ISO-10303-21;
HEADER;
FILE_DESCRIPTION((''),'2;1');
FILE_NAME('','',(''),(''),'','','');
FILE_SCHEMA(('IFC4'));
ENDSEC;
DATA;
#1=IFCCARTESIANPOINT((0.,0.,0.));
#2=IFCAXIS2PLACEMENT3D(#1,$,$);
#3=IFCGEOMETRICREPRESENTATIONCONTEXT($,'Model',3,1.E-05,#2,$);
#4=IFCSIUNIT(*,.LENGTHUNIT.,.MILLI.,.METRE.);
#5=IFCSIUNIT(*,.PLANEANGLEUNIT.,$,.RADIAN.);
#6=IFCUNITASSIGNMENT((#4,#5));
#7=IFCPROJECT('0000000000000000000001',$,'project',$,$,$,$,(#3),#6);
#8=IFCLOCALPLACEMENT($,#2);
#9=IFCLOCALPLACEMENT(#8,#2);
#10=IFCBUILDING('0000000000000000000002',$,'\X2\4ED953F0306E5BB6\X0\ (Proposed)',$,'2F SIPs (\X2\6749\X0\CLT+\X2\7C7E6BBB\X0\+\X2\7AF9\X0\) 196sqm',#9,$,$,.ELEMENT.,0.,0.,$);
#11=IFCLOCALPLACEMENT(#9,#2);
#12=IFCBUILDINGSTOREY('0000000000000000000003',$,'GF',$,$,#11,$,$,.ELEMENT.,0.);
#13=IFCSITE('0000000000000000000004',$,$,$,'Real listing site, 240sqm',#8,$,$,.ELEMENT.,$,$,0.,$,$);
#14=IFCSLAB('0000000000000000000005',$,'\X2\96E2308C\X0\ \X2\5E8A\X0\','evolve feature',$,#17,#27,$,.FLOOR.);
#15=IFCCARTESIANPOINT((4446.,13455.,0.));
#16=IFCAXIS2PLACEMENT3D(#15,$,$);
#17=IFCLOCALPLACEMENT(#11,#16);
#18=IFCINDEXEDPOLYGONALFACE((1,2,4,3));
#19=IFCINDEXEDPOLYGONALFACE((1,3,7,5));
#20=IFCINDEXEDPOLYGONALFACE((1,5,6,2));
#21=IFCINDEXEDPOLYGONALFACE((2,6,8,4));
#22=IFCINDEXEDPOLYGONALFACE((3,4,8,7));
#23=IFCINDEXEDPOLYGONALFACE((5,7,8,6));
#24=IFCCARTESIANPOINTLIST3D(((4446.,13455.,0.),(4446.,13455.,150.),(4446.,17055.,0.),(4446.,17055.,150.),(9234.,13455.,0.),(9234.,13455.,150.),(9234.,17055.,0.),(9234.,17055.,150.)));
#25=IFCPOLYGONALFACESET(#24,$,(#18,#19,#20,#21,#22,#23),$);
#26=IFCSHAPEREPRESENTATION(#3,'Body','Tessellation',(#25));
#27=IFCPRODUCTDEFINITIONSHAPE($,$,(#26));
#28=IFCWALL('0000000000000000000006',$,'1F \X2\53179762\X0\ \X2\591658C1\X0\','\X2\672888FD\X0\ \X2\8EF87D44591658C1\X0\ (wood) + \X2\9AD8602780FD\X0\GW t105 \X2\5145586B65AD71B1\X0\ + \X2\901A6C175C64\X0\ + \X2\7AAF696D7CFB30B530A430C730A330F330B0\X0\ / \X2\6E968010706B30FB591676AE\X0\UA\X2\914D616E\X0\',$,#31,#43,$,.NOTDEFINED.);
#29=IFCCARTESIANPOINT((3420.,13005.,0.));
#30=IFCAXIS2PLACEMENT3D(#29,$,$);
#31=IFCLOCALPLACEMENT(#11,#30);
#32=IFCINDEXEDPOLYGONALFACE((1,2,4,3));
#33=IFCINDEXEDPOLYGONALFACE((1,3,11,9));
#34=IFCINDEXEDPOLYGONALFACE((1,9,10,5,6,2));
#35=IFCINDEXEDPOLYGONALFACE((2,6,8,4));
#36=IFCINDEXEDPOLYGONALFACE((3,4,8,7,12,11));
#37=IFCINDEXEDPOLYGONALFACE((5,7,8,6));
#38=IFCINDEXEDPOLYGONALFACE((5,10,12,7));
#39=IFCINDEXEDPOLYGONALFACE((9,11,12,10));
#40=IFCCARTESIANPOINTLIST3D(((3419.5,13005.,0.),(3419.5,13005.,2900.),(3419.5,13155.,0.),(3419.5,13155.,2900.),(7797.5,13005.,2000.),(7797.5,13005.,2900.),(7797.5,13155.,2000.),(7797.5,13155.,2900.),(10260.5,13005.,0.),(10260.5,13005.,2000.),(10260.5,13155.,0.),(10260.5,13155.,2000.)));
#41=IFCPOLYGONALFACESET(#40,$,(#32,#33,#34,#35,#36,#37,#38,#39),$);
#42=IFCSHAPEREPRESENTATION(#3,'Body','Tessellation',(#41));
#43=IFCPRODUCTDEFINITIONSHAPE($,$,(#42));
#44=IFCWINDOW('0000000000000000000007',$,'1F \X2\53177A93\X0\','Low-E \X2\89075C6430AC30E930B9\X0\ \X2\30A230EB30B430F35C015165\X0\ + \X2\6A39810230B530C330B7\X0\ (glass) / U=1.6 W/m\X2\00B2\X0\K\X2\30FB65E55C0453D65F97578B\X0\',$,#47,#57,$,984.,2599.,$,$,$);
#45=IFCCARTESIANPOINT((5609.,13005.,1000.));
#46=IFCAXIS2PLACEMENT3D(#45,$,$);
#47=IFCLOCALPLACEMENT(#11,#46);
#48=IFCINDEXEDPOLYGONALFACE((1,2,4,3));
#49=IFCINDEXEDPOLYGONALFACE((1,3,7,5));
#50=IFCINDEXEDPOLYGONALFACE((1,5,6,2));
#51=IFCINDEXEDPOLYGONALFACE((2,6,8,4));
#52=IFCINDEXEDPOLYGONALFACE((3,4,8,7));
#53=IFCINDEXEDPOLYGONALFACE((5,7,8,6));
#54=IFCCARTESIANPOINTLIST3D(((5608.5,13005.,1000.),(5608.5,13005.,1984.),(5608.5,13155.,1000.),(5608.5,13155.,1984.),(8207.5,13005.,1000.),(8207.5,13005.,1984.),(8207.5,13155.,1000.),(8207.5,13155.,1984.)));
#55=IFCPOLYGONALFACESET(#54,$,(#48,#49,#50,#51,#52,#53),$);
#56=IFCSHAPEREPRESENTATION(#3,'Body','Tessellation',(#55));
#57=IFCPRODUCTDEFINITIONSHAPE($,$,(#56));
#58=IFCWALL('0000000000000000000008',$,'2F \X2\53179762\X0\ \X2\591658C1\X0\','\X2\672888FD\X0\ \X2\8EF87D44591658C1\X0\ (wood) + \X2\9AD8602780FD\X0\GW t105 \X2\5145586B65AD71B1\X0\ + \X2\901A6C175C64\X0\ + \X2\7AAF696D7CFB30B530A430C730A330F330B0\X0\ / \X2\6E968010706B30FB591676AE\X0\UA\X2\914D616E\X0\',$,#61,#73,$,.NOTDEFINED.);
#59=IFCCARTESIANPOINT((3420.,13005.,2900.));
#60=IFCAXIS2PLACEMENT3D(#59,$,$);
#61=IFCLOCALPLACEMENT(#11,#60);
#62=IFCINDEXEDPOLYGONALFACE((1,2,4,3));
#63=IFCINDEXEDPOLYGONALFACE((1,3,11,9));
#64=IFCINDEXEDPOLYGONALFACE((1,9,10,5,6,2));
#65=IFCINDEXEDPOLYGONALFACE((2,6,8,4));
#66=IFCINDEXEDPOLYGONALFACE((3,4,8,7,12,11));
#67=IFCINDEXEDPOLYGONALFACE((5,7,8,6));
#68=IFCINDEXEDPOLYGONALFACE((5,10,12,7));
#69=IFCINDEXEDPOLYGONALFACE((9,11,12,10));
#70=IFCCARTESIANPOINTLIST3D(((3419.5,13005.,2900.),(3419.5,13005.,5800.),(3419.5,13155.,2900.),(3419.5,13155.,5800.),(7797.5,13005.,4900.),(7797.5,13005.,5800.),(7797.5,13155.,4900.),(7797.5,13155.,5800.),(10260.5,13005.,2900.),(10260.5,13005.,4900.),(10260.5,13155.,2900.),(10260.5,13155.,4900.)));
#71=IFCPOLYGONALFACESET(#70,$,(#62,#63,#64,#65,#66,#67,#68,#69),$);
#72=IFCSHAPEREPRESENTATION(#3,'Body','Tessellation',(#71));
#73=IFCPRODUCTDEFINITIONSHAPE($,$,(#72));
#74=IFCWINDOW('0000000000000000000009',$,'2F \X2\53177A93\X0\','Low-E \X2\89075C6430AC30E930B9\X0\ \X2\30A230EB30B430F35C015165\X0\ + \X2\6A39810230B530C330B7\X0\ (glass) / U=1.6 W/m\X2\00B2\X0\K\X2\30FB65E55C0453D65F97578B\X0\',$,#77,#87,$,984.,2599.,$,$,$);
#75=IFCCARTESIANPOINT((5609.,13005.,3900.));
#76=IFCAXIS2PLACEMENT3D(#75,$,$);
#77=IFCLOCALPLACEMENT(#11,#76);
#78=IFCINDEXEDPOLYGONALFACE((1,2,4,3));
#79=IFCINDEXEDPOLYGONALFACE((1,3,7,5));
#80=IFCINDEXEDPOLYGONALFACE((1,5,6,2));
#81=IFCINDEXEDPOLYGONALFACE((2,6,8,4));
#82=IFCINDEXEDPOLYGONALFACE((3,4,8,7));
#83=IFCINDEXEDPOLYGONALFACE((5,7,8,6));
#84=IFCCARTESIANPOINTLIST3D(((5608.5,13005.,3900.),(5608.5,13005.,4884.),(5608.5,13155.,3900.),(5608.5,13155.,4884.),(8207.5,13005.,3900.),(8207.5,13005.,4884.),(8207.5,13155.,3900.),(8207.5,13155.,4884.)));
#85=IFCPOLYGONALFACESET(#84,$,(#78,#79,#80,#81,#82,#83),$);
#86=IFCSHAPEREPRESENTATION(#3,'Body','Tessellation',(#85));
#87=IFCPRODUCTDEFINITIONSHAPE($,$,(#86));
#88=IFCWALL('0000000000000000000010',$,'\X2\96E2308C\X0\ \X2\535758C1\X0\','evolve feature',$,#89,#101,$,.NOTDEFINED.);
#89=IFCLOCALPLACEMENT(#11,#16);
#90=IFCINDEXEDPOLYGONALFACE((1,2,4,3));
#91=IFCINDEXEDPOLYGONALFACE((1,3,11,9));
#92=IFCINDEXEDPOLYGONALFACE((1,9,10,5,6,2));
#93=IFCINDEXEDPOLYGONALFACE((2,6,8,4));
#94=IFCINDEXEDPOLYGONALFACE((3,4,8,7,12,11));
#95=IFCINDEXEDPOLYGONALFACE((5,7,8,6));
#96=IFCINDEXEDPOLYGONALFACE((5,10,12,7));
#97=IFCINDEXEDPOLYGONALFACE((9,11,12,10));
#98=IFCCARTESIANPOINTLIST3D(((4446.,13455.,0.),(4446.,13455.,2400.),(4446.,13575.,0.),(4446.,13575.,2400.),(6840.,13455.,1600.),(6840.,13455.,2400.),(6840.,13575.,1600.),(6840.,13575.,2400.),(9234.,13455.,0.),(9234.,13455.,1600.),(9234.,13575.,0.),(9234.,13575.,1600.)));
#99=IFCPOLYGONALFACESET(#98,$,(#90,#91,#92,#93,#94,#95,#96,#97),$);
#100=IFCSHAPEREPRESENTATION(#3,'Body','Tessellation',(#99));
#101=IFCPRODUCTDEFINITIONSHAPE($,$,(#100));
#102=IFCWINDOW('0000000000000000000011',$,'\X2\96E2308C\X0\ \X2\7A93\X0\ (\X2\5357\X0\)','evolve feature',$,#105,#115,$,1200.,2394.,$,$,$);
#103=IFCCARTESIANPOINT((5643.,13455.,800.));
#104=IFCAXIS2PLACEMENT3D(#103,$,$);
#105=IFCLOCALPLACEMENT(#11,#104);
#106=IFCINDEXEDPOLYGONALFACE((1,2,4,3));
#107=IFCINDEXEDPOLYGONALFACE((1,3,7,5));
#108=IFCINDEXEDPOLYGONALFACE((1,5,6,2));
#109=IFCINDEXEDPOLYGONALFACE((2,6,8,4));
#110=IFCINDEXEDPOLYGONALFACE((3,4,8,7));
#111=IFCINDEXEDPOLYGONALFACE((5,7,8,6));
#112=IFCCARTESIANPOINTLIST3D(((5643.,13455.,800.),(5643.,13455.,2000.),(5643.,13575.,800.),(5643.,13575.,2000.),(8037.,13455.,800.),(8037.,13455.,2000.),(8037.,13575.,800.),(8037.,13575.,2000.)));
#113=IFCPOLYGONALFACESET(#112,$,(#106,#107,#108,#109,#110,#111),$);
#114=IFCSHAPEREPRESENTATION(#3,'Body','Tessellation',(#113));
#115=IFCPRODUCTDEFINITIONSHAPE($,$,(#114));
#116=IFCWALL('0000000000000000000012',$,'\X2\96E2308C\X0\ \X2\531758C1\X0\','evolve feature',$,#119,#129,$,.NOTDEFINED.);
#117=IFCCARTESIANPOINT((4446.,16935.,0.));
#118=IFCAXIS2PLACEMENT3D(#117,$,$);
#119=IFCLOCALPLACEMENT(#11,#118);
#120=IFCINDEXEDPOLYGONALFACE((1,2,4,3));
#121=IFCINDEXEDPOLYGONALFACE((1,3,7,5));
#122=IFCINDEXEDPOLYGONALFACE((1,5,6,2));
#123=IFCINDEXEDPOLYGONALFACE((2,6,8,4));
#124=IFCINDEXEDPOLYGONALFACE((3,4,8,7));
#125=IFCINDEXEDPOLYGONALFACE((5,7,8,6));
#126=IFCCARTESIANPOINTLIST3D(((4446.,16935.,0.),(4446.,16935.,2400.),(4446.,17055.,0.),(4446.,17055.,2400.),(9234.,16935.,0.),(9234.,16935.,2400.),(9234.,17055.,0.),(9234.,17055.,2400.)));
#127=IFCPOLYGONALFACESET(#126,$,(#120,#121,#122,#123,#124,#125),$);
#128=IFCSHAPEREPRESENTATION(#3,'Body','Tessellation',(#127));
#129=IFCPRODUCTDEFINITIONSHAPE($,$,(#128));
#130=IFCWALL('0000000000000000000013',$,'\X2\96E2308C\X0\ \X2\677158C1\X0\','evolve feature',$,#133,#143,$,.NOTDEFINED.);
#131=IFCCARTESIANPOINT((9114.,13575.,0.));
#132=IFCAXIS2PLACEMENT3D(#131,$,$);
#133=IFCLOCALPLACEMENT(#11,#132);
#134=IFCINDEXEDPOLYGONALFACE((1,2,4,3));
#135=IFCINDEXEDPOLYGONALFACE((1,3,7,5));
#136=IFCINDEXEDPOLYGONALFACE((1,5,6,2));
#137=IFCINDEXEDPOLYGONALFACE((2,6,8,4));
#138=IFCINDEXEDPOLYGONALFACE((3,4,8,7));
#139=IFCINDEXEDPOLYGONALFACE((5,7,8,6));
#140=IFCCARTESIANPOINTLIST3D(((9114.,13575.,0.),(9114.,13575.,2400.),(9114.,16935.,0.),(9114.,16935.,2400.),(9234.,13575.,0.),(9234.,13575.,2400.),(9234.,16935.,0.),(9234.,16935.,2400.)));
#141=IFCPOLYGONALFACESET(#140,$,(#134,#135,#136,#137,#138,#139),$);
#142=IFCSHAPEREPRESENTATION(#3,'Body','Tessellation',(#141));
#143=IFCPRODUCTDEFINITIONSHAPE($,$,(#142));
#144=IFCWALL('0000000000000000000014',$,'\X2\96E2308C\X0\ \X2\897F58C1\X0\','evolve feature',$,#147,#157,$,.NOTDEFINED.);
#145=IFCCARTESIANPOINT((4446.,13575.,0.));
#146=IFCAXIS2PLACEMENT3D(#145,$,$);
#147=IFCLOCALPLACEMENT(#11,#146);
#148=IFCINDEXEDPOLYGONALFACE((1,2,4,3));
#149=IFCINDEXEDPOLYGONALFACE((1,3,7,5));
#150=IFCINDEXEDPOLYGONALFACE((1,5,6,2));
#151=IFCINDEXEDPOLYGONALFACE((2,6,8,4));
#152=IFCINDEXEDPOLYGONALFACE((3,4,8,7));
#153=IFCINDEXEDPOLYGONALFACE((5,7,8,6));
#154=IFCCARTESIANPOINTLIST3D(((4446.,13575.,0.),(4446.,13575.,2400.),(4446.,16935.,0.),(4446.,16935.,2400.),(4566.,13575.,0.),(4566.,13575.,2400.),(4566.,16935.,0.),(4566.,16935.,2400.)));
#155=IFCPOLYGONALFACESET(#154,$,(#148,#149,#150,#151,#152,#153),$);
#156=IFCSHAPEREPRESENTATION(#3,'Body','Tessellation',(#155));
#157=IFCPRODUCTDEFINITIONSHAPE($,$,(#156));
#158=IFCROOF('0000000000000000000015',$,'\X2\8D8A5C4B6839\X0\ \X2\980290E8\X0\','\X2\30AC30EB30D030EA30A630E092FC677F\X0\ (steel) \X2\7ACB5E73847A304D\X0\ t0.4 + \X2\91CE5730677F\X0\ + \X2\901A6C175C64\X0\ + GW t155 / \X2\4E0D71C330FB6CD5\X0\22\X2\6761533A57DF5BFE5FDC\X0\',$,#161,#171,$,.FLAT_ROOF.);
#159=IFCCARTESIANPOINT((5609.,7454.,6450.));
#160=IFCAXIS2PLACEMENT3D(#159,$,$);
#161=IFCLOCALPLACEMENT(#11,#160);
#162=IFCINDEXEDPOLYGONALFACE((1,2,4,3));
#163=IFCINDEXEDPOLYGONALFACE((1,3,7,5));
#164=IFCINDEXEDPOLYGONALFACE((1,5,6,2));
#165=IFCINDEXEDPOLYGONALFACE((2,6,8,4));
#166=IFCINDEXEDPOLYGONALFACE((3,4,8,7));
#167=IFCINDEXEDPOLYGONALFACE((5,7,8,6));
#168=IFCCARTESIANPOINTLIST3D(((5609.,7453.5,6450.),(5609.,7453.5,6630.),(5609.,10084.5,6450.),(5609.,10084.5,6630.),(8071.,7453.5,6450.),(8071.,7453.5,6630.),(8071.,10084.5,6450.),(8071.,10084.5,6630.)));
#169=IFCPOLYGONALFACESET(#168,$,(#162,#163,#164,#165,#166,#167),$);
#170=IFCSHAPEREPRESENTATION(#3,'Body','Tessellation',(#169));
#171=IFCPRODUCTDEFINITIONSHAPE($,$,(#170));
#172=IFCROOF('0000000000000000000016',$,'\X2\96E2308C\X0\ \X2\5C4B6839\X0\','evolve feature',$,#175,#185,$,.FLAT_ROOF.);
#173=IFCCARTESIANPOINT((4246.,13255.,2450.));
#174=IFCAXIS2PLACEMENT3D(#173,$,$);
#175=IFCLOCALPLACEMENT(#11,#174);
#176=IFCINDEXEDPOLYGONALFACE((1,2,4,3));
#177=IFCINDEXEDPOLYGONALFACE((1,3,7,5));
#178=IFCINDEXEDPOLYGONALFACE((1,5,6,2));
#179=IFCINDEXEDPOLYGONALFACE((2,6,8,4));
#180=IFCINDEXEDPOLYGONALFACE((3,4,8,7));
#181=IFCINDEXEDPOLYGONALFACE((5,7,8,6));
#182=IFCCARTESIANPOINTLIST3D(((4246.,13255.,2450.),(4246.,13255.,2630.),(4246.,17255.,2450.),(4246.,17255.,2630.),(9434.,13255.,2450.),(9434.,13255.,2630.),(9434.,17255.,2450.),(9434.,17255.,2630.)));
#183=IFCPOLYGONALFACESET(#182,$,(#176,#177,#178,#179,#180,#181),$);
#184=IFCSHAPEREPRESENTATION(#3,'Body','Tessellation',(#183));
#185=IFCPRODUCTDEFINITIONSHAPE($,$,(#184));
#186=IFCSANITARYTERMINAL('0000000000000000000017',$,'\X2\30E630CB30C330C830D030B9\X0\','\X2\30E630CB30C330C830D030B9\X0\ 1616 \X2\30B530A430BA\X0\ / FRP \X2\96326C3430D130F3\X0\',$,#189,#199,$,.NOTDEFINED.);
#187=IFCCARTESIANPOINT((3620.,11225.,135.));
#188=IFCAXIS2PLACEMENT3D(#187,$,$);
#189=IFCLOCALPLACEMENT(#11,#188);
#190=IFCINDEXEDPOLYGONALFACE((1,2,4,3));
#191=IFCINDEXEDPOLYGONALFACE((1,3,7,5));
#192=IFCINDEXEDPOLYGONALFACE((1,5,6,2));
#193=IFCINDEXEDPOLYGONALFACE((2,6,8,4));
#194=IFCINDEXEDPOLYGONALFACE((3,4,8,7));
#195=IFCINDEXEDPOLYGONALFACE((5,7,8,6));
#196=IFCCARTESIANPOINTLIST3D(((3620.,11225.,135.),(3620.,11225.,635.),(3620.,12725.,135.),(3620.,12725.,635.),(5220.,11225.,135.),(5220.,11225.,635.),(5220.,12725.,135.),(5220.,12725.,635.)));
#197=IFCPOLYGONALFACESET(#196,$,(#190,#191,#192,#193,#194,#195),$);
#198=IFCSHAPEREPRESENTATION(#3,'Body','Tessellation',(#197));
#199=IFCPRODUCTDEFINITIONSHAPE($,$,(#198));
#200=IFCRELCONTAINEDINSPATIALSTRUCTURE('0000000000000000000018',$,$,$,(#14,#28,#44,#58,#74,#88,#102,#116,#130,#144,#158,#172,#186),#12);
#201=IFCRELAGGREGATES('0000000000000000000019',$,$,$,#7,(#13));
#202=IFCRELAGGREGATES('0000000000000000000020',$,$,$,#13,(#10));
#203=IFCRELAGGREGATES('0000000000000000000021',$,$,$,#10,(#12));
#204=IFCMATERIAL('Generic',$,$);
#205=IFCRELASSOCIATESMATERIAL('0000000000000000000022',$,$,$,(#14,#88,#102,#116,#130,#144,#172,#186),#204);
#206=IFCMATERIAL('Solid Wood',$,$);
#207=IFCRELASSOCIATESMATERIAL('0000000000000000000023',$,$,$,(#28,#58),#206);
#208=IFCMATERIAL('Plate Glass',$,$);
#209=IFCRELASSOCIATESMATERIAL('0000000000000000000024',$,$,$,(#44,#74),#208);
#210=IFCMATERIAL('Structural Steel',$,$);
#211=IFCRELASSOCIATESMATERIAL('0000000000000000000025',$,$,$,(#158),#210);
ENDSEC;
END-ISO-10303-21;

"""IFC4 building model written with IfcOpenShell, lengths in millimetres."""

from ifc_helpers import new_model, si_unit, frame, frame_2d, origin, place, context, project, spatial, rectangle, extrude, material, element, fill, save


model = new_model("IFC4")

# Units and contexts
model_context = context("Model", 3, precision=1e-05, world=origin())
ifc_project = project(units=[si_unit("LENGTHUNIT", "METRE", prefix="MILLI"), si_unit("PLANEANGLEUNIT", "RADIAN")], contexts=[model_context])

# Site, building, storey
site_placement = place(None, origin())
site = spatial("IfcSite", under=ifc_project, at=site_placement, ObjectType="Real listing site, 240sqm", CompositionType="ELEMENT", RefElevation=0.0)
building_placement = place(site_placement, origin())
building = spatial("IfcBuilding", under=site, at=building_placement, Name="仙台の家 (Proposed)", ObjectType="2F SIPs (杉CLT+籾殻+竹) 196sqm", CompositionType="ELEMENT", ElevationOfRefHeight=0.0, ElevationOfTerrain=0.0)
storey_placement = place(building_placement, origin())
storey = spatial("IfcBuildingStorey", under=building, at=storey_placement, Name="GF", CompositionType="ELEMENT", Elevation=0.0)

# Slab
ifc_material_1 = material(Name="Generic")
slab_placement = place(storey_placement, frame((4446.0, 13455.0, 0.0)))
element("IfcSlab", 1, at=slab_placement, inside=storey, material=ifc_material_1, Name="離れ 床", Description="evolve feature", PredefinedType="FLOOR", context=model_context, shape_type="SweptSolid", body=[
    extrude(rectangle(XDim=4788.0, YDim=3600.0, at=frame_2d((2394.0, 1800.0))), frame((4446.0, 13455.0, 0.0)), (0.0, 0.0, 1.0), 150.0),
])

# Wall, opening, window
ifc_material_2 = material(Name="Solid Wood")
wall_1_placement = place(storey_placement, frame((3420.0, 13005.0, 0.0)))
wall_1 = element("IfcWall", 2, at=wall_1_placement, inside=storey, material=ifc_material_2, Name="1F 北面 外壁", Description="木製 軸組外壁 (wood) + 高性能GW t105 充填断熱 + 通気層 + 窯業系サイディング / 準耐火・外皮UA配慮", PredefinedType="NOTDEFINED", context=model_context, shape_type="SweptSolid", body=[
    extrude(rectangle(XDim=6841.0, YDim=150.0, at=frame_2d((3420.0, 75.0))), frame((3420.0, 13005.0, 0.0)), (0.0, 0.0, 1.0), 2900.0),
])
opening_1_placement = place(storey_placement, frame((5609.0, 13005.0, 1000.0)))
opening_1 = element("IfcOpeningElement", 3, at=opening_1_placement, cuts=wall_1, PredefinedType="NOTDEFINED", context=model_context, shape_type="SweptSolid", body=[
    extrude(rectangle(XDim=2599.0, YDim=150.0, at=frame_2d((1299.0, 75.0))), frame((5609.0, 13005.0, 1000.0)), (0.0, 0.0, 1.0), 984.0),
])
ifc_material_3 = material(Name="Plate Glass")
window_1_placement = place(storey_placement, frame((5609.0, 13005.0, 1000.0)))
window_1 = element("IfcWindow", 4, at=window_1_placement, inside=storey, material=ifc_material_3, Name="1F 北窓", Description="Low-E 複層ガラス アルゴン封入 + 樹脂サッシ (glass) / U=1.6 W/m²K・日射取得型", OverallHeight=984.0, OverallWidth=2599.0, context=model_context, shape_type="SweptSolid", body=[
    extrude(rectangle(XDim=2599.0, YDim=150.0, at=frame_2d((1299.0, 75.0))), frame((5609.0, 13005.0, 1000.0)), (0.0, 0.0, 1.0), 984.0),
])
fill(opening_1, window_1)

# Wall, opening, window
wall_2_placement = place(storey_placement, frame((3420.0, 13005.0, 2900.0)))
wall_2 = element("IfcWall", 5, at=wall_2_placement, inside=storey, material=ifc_material_2, Name="2F 北面 外壁", Description="木製 軸組外壁 (wood) + 高性能GW t105 充填断熱 + 通気層 + 窯業系サイディング / 準耐火・外皮UA配慮", PredefinedType="NOTDEFINED", context=model_context, shape_type="SweptSolid", body=[
    extrude(rectangle(XDim=6841.0, YDim=150.0, at=frame_2d((3420.0, 75.0))), frame((3420.0, 13005.0, 2900.0)), (0.0, 0.0, 1.0), 2900.0),
])
opening_2_placement = place(storey_placement, frame((5609.0, 13005.0, 3900.0)))
opening_2 = element("IfcOpeningElement", 6, at=opening_2_placement, cuts=wall_2, PredefinedType="NOTDEFINED", context=model_context, shape_type="SweptSolid", body=[
    extrude(rectangle(XDim=2599.0, YDim=150.0, at=frame_2d((1299.0, 75.0))), frame((5609.0, 13005.0, 3900.0)), (0.0, 0.0, 1.0), 984.0),
])
window_2_placement = place(storey_placement, frame((5609.0, 13005.0, 3900.0)))
window_2 = element("IfcWindow", 7, at=window_2_placement, inside=storey, material=ifc_material_3, Name="2F 北窓", Description="Low-E 複層ガラス アルゴン封入 + 樹脂サッシ (glass) / U=1.6 W/m²K・日射取得型", OverallHeight=984.0, OverallWidth=2599.0, context=model_context, shape_type="SweptSolid", body=[
    extrude(rectangle(XDim=2599.0, YDim=150.0, at=frame_2d((1299.0, 75.0))), frame((5609.0, 13005.0, 3900.0)), (0.0, 0.0, 1.0), 984.0),
])
fill(opening_2, window_2)

# Wall, opening, window
wall_3_placement = place(storey_placement, frame((4446.0, 13455.0, 0.0)))
wall_3 = element("IfcWall", 8, at=wall_3_placement, inside=storey, material=ifc_material_1, Name="離れ 南壁", Description="evolve feature", PredefinedType="NOTDEFINED", context=model_context, shape_type="SweptSolid", body=[
    extrude(rectangle(XDim=4788.0, YDim=120.0, at=frame_2d((2394.0, 60.0))), frame((4446.0, 13455.0, 0.0)), (0.0, 0.0, 1.0), 2400.0),
])
opening_3_placement = place(storey_placement, frame((5643.0, 13455.0, 800.0)))
opening_3 = element("IfcOpeningElement", 9, at=opening_3_placement, cuts=wall_3, PredefinedType="NOTDEFINED", context=model_context, shape_type="SweptSolid", body=[
    extrude(rectangle(XDim=2394.0, YDim=120.0, at=frame_2d((1197.0, 60.0))), frame((5643.0, 13455.0, 800.0)), (0.0, 0.0, 1.0), 1200.0),
])
window_3_placement = place(storey_placement, frame((5643.0, 13455.0, 800.0)))
window_3 = element("IfcWindow", 10, at=window_3_placement, inside=storey, material=ifc_material_1, Name="離れ 窓 (南)", Description="evolve feature", OverallHeight=1200.0, OverallWidth=2394.0, context=model_context, shape_type="SweptSolid", body=[
    extrude(rectangle(XDim=2394.0, YDim=120.0, at=frame_2d((1197.0, 60.0))), frame((5643.0, 13455.0, 800.0)), (0.0, 0.0, 1.0), 1200.0),
])
fill(opening_3, window_3)

# Walls
wall_4_placement = place(storey_placement, frame((4446.0, 16935.0, 0.0)))
element("IfcWall", 11, at=wall_4_placement, inside=storey, material=ifc_material_1, Name="離れ 北壁", Description="evolve feature", PredefinedType="NOTDEFINED", context=model_context, shape_type="SweptSolid", body=[
    extrude(rectangle(XDim=4788.0, YDim=120.0, at=frame_2d((2394.0, 60.0))), frame((4446.0, 16935.0, 0.0)), (0.0, 0.0, 1.0), 2400.0),
])
wall_5_placement = place(storey_placement, frame((9114.0, 13575.0, 0.0)))
element("IfcWall", 12, at=wall_5_placement, inside=storey, material=ifc_material_1, Name="離れ 東壁", Description="evolve feature", PredefinedType="NOTDEFINED", context=model_context, shape_type="SweptSolid", body=[
    extrude(rectangle(XDim=120.0, YDim=3360.0, at=frame_2d((60.0, 1680.0))), frame((9114.0, 13575.0, 0.0)), (0.0, 0.0, 1.0), 2400.0),
])
wall_6_placement = place(storey_placement, frame((4446.0, 13575.0, 0.0)))
element("IfcWall", 13, at=wall_6_placement, inside=storey, material=ifc_material_1, Name="離れ 西壁", Description="evolve feature", PredefinedType="NOTDEFINED", context=model_context, shape_type="SweptSolid", body=[
    extrude(rectangle(XDim=120.0, YDim=3360.0, at=frame_2d((60.0, 1680.0))), frame((4446.0, 13575.0, 0.0)), (0.0, 0.0, 1.0), 2400.0),
])

# Roofs
ifc_material_4 = material(Name="Structural Steel")
roof_1_placement = place(storey_placement, frame((5609.0, 7454.0, 6450.0)))
element("IfcRoof", 14, at=roof_1_placement, inside=storey, material=ifc_material_4, Name="越屋根 頂部", Description="ガルバリウム鋼板 (steel) 立平葺き t0.4 + 野地板 + 通気層 + GW t155 / 不燃・法22条区域対応", PredefinedType="FLAT_ROOF", context=model_context, shape_type="SweptSolid", body=[
    extrude(rectangle(XDim=2462.0, YDim=2631.0, at=frame_2d((1231.0, 1315.0))), frame((5609.0, 7454.0, 6450.0)), (0.0, 0.0, 1.0), 180.0),
])
roof_2_placement = place(storey_placement, frame((4246.0, 13255.0, 2450.0)))
element("IfcRoof", 15, at=roof_2_placement, inside=storey, material=ifc_material_1, Name="離れ 屋根", Description="evolve feature", PredefinedType="FLAT_ROOF", context=model_context, shape_type="SweptSolid", body=[
    extrude(rectangle(XDim=5188.0, YDim=4000.0, at=frame_2d((2594.0, 2000.0))), frame((4246.0, 13255.0, 2450.0)), (0.0, 0.0, 1.0), 180.0),
])

# Sanitary terminal
sanitary_terminal_1_placement = place(storey_placement, frame((3620.0, 11225.0, 135.0)))
element("IfcSanitaryTerminal", 16, at=sanitary_terminal_1_placement, inside=storey, material=ifc_material_1, Name="ユニットバス", Description="ユニットバス 1616 サイズ / FRP 防水パン", PredefinedType="NOTDEFINED", context=model_context, shape_type="SweptSolid", body=[
    extrude(rectangle(XDim=1600.0, YDim=1500.0, at=frame_2d((800.0, 750.0))), frame((3620.0, 11225.0, 135.0)), (0.0, 0.0, 1.0), 500.0),
])

save(model, "model.ifc")
